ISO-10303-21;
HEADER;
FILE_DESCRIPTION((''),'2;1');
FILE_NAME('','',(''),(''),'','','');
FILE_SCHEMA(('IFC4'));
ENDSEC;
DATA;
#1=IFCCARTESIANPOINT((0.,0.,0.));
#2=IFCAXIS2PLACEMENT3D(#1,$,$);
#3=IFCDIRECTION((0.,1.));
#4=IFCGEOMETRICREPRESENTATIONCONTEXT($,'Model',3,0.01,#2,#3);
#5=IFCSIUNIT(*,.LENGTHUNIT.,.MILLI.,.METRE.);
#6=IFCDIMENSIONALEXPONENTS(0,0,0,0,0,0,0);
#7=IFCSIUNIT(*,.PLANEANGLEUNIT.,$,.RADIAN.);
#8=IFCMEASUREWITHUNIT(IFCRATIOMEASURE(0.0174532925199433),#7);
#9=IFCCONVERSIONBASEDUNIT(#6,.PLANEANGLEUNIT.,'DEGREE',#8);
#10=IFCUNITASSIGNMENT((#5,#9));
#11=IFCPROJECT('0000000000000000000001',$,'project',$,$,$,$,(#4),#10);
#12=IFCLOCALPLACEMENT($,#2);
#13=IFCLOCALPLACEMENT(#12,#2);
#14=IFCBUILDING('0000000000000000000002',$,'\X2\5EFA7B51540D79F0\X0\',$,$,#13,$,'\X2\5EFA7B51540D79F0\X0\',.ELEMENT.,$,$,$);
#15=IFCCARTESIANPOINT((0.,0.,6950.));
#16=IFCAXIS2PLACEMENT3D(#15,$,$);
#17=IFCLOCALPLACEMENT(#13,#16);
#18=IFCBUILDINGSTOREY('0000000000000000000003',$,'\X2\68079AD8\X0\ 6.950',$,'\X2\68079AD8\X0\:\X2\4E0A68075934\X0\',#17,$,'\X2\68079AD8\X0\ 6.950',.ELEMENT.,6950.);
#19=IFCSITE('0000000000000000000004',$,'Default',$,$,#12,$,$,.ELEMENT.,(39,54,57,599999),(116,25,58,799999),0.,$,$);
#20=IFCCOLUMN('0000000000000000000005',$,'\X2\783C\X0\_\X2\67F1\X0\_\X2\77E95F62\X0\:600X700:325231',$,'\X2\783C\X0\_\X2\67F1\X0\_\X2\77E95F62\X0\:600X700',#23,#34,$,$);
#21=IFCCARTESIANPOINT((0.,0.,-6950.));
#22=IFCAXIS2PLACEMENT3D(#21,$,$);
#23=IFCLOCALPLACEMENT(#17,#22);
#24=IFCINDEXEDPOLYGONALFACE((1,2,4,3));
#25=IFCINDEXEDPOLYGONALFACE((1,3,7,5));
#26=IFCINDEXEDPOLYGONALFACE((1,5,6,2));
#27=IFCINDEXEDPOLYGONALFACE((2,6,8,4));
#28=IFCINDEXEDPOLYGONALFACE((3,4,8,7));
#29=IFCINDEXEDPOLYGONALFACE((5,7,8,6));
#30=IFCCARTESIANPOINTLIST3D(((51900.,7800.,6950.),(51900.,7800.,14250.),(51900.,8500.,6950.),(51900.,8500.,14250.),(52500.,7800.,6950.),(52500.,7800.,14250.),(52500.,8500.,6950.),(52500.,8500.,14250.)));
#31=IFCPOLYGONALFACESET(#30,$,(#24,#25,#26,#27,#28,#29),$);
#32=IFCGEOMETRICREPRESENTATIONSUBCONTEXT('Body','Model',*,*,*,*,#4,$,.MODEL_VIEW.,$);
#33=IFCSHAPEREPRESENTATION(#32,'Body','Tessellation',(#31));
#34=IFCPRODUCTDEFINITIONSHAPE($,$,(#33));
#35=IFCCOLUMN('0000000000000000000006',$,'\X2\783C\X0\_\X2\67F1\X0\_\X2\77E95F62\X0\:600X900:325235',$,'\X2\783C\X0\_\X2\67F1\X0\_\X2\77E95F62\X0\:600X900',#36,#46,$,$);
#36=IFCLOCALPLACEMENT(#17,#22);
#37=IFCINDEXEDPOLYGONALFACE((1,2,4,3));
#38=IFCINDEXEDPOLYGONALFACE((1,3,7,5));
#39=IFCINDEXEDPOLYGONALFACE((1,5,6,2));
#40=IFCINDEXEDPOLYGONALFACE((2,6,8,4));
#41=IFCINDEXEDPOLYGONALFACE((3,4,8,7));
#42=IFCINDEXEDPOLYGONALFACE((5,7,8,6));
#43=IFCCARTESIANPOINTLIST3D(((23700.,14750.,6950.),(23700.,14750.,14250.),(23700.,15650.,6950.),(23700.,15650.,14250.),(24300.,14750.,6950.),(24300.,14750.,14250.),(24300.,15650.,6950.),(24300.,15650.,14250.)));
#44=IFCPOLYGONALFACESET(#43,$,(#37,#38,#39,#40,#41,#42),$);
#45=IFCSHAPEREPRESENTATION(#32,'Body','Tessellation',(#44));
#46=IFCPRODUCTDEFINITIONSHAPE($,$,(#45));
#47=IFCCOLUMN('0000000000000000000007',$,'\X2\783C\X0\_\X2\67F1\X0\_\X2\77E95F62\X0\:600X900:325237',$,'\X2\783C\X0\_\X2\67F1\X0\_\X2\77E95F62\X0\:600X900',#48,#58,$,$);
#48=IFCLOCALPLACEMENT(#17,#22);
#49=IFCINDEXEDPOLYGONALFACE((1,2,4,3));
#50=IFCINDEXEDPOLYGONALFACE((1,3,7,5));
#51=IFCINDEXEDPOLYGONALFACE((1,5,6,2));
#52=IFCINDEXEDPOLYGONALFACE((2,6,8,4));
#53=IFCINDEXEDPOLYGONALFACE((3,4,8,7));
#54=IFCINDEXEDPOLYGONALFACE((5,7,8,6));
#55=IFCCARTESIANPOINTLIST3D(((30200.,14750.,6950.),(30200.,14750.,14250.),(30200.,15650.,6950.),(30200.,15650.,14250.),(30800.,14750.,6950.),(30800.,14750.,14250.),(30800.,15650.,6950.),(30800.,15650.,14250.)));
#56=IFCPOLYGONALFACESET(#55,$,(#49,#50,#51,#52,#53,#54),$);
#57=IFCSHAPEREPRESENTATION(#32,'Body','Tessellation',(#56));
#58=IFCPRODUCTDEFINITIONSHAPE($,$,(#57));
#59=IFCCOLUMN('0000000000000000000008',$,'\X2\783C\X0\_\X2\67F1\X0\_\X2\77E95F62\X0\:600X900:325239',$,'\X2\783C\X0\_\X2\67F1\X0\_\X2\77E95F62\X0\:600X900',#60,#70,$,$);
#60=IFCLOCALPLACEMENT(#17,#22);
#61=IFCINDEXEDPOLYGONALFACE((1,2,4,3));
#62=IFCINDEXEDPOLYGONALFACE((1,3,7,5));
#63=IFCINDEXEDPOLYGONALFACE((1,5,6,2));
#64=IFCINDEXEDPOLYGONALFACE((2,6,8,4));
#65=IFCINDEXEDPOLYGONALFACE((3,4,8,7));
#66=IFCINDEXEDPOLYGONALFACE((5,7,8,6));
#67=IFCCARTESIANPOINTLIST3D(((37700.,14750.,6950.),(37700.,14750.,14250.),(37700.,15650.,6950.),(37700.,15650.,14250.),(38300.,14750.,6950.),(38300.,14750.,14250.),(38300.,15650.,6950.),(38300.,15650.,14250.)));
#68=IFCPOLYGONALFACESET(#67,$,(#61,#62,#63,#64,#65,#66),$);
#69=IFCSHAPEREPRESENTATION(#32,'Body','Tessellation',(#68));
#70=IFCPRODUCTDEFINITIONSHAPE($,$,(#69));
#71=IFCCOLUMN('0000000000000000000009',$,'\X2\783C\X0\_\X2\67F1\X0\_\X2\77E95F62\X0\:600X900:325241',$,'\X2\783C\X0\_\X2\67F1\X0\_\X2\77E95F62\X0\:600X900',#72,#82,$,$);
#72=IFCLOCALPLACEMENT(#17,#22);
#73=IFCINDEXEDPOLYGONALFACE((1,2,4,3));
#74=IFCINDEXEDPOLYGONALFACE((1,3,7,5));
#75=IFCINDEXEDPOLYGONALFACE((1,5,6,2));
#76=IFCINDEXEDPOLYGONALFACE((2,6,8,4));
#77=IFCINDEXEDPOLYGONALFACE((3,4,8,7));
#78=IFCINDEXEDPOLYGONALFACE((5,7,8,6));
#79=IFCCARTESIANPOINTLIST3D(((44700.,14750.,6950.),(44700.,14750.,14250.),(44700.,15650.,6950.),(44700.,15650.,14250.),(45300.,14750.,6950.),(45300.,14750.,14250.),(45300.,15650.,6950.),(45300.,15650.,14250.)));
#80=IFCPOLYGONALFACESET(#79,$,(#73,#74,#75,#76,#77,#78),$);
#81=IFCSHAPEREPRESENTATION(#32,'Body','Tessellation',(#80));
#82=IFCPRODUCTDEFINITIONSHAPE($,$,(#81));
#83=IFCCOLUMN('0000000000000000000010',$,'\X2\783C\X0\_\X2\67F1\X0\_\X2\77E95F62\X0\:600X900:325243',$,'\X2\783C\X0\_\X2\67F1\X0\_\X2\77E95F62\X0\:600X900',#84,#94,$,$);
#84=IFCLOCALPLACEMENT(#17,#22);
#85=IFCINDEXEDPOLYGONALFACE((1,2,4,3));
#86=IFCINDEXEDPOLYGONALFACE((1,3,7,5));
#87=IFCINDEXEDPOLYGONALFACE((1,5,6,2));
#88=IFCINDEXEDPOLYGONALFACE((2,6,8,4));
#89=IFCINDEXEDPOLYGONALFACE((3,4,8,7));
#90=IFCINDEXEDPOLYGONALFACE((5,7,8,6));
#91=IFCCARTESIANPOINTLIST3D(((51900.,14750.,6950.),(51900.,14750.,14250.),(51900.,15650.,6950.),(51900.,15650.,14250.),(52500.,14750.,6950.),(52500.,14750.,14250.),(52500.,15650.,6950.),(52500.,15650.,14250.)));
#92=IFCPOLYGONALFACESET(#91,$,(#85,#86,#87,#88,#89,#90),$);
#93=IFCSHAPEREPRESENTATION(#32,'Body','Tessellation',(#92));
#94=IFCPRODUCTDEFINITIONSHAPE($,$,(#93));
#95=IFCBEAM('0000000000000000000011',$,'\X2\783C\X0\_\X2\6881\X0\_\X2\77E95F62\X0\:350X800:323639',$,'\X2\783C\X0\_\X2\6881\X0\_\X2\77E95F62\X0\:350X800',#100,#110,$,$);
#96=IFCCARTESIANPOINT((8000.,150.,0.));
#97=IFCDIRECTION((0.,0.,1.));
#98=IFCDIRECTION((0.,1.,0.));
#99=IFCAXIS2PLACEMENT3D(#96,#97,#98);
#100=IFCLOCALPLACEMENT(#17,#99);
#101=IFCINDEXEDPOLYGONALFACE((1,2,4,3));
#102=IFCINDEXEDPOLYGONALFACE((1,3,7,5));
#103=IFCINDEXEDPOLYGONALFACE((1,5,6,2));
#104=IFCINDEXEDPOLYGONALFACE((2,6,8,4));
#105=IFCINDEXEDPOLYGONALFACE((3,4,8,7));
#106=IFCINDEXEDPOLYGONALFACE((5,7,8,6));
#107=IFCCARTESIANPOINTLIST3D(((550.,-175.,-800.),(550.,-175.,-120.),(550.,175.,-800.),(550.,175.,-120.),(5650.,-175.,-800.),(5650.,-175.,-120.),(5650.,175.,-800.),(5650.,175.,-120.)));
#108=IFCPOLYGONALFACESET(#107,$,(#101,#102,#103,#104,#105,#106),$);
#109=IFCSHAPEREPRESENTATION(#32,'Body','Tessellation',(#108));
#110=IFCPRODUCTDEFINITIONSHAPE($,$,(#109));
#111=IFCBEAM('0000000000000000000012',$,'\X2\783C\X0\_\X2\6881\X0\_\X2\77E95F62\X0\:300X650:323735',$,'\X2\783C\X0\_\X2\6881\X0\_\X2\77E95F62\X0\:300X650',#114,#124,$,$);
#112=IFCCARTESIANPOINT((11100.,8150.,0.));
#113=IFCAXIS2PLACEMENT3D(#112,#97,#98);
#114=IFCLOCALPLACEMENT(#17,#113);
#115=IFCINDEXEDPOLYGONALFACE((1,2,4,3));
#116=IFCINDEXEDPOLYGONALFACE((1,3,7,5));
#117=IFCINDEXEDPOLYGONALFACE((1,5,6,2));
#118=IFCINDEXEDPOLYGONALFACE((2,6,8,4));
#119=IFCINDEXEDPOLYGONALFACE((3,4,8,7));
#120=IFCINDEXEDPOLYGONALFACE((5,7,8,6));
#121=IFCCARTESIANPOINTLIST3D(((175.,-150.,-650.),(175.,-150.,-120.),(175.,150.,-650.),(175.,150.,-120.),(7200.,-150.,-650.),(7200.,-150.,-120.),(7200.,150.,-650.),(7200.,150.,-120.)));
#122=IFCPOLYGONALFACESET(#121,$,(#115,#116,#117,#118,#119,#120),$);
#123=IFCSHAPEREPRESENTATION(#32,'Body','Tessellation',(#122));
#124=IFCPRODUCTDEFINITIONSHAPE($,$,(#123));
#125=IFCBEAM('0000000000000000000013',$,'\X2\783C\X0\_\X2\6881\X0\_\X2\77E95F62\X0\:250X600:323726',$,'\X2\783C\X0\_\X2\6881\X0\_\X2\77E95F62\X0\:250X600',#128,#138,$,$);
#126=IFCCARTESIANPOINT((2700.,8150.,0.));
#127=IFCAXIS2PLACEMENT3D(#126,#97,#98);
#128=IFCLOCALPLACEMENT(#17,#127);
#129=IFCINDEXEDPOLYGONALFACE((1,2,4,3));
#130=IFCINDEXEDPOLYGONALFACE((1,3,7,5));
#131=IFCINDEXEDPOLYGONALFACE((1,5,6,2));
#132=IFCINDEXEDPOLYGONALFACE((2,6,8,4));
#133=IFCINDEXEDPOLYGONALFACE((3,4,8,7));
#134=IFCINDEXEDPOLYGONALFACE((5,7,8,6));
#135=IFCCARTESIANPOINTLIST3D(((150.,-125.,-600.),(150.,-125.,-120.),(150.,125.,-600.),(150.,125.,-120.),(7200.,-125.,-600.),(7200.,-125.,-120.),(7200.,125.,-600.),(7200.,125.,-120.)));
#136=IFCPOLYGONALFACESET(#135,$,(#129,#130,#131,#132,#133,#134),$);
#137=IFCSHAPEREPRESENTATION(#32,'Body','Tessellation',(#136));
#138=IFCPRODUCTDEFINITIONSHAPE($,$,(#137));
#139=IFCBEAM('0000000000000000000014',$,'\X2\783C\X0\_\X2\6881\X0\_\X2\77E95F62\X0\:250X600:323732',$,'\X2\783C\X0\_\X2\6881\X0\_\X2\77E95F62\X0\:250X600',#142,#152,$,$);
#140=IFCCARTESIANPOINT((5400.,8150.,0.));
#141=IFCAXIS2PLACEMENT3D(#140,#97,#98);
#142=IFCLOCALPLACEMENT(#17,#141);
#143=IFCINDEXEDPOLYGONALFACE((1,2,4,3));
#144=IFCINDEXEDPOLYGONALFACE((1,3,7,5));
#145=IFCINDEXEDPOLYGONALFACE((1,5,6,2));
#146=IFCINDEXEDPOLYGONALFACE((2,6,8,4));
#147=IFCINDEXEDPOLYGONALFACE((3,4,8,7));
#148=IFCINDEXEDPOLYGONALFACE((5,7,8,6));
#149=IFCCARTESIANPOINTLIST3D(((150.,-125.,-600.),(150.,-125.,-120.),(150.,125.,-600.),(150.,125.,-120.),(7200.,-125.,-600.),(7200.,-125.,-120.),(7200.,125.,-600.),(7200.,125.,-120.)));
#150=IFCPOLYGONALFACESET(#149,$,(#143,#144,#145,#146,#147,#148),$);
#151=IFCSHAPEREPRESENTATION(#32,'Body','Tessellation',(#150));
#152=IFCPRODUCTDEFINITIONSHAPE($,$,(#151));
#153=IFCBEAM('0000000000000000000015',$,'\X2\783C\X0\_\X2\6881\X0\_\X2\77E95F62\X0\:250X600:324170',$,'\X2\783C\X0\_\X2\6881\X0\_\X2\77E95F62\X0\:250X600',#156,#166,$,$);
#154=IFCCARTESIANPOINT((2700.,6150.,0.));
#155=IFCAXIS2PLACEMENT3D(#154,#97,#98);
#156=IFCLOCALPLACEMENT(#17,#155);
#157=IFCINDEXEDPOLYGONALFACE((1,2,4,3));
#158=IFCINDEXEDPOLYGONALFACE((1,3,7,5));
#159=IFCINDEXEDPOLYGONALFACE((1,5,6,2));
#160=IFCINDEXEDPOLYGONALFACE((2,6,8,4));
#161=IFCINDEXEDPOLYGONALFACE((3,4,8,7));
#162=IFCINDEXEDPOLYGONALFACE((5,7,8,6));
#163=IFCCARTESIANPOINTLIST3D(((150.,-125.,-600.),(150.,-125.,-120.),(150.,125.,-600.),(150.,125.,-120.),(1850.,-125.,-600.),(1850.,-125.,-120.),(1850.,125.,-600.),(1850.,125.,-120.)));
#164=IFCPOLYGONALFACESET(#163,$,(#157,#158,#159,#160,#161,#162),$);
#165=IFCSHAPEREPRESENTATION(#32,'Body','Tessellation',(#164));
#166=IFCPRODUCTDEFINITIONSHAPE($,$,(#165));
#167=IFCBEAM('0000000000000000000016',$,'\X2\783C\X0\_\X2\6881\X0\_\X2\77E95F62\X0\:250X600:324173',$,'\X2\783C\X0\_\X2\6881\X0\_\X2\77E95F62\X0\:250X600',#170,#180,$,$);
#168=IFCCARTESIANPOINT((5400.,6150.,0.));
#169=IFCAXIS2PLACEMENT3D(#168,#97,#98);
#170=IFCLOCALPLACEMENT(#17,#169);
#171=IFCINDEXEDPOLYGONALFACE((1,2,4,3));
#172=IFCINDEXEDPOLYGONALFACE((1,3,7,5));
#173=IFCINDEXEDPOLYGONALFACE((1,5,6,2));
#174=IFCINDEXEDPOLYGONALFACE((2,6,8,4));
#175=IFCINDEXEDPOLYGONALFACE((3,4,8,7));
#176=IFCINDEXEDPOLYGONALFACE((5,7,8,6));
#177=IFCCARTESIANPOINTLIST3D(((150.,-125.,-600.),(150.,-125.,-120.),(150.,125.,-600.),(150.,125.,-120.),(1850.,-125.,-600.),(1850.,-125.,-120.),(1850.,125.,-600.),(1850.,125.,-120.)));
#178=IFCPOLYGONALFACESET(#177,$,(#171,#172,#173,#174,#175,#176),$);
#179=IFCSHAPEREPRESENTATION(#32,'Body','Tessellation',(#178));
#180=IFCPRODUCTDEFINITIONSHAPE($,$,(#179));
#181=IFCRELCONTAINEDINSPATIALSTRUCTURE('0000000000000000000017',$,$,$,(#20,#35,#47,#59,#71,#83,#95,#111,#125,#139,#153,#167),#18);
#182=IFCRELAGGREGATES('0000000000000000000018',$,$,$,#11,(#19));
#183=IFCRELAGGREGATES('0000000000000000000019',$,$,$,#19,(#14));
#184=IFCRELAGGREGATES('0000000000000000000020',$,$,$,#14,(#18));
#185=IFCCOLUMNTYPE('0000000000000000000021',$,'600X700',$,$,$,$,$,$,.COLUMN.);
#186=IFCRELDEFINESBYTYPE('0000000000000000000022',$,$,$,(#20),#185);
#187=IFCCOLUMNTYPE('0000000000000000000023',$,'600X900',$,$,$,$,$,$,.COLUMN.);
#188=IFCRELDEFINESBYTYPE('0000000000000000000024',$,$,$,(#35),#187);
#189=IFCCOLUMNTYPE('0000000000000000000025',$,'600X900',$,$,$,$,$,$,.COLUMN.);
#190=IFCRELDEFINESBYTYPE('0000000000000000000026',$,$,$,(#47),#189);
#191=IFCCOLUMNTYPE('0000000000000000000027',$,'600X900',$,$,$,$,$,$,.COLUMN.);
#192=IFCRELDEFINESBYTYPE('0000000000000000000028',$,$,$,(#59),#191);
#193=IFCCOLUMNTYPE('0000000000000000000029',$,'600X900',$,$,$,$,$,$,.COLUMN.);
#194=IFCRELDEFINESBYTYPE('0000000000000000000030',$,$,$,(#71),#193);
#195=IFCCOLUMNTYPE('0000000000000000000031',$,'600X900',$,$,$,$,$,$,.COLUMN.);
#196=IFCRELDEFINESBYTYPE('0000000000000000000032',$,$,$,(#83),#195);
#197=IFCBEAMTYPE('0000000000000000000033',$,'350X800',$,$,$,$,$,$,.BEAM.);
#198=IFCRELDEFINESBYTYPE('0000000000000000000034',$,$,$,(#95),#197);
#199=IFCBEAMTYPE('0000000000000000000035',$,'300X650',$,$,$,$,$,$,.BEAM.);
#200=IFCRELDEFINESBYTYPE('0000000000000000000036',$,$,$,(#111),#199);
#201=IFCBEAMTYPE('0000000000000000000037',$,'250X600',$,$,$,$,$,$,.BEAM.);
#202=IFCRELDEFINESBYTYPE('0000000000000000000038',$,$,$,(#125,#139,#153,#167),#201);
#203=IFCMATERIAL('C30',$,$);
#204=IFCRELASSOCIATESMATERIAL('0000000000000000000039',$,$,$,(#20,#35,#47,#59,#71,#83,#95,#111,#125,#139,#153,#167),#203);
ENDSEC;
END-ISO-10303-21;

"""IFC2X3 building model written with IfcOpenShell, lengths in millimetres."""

from ifc_helpers import new_model, entity, si_unit, converted_unit, direction, frame, frame_2d, origin, origin_2d_with_axis, place, context, subcontext, project, spatial, rectangle, extrude, source, transform, mapped, material, type_object, type_shapes, element, save


model = new_model("IFC2X3")

# Units and contexts
model_context = context("Model", 3, precision=0.01, world=origin(), true_north=direction((0.0, 1.0)))
body_context = subcontext(model_context, "Body", "Model", "MODEL_VIEW")
ifc_project = project(units=[si_unit("LENGTHUNIT", "METRE", prefix="MILLI"), converted_unit("PLANEANGLEUNIT", "DEGREE", entity("IfcRatioMeasure", 0.0174532925199433), si_unit("PLANEANGLEUNIT", "RADIAN"), dimensions=[0, 0, 0, 0, 0, 0, 0])], contexts=[model_context])

# Site, building, storey
site_placement = place(None, origin())
site = spatial("IfcSite", under=ifc_project, at=site_placement, Name="Default", CompositionType="ELEMENT", RefLatitude=(39, 54, 57, 599999), RefLongitude=(116, 25, 58, 799999), RefElevation=0.0)
building_placement = place(site_placement, origin())
building = spatial("IfcBuilding", under=site, at=building_placement, Name="建筑名称", LongName="建筑名称", CompositionType="ELEMENT")
storey_placement = place(building_placement, frame((0.0, 0.0, 6950.0)))
storey = spatial("IfcBuildingStorey", under=building, at=storey_placement, Name="标高 6.950", ObjectType="标高:上标头", LongName="标高 6.950", CompositionType="ELEMENT", Elevation=6950.0)

# Columns
ifc_material = material(Name="C30")
column_type_1 = type_object("IfcColumnType", Name="600X700", PredefinedType="COLUMN")
shared_shape_1 = source(origin(), body_context, "Body", "SweptSolid", [
    extrude(rectangle(XDim=700.0, YDim=600.0, at=origin_2d_with_axis()), frame((52200.0, 8150.0, 6950.0), z_axis=(0.0, 0.0, 1.0), x_axis=(0.0, -1.0, 0.0)), (0.0, 0.0, 1.0), 7300.0),
])
type_shapes(column_type_1, [shared_shape_1])
column_1_placement = place(storey_placement, frame((0.0, 0.0, -6950.0)))
element("IfcColumn", 1, at=column_1_placement, inside=storey, type_object=column_type_1, material=ifc_material, Name="砼_柱_矩形:600X700:325231", ObjectType="砼_柱_矩形:600X700", context=body_context, shape_type="MappedRepresentation", body=[
    mapped(shared_shape_1, transform((0.0, 0.0, 0.0), scale=1.0)),
])
column_type_2 = type_object("IfcColumnType", Name="600X900", PredefinedType="COLUMN")
shared_shape_2 = source(origin(), body_context, "Body", "SweptSolid", [
    extrude(rectangle(XDim=900.0, YDim=600.0, at=origin_2d_with_axis()), frame((24000.0, 15200.0, 6950.0), z_axis=(0.0, 0.0, 1.0), x_axis=(0.0, -1.0, 0.0)), (0.0, 0.0, 1.0), 7300.0),
])
type_shapes(column_type_2, [shared_shape_2])
column_2_placement = place(storey_placement, frame((0.0, 0.0, -6950.0)))
element("IfcColumn", 2, at=column_2_placement, inside=storey, type_object=column_type_2, material=ifc_material, Name="砼_柱_矩形:600X900:325235", ObjectType="砼_柱_矩形:600X900", context=body_context, shape_type="MappedRepresentation", body=[
    mapped(shared_shape_2, transform((0.0, 0.0, 0.0), scale=1.0)),
])
column_type_3 = type_object("IfcColumnType", Name="600X900", PredefinedType="COLUMN")
shared_shape_3 = source(origin(), body_context, "Body", "SweptSolid", [
    extrude(rectangle(XDim=900.0, YDim=600.0, at=origin_2d_with_axis()), frame((30500.0, 15200.0, 6950.0), z_axis=(0.0, 0.0, 1.0), x_axis=(0.0, -1.0, 0.0)), (0.0, 0.0, 1.0), 7300.0),
])
type_shapes(column_type_3, [shared_shape_3])
column_3_placement = place(storey_placement, frame((0.0, 0.0, -6950.0)))
element("IfcColumn", 3, at=column_3_placement, inside=storey, type_object=column_type_3, material=ifc_material, Name="砼_柱_矩形:600X900:325237", ObjectType="砼_柱_矩形:600X900", context=body_context, shape_type="MappedRepresentation", body=[
    mapped(shared_shape_3, transform((0.0, 0.0, 0.0), scale=1.0)),
])
column_type_4 = type_object("IfcColumnType", Name="600X900", PredefinedType="COLUMN")
shared_shape_4 = source(origin(), body_context, "Body", "SweptSolid", [
    extrude(rectangle(XDim=900.0, YDim=600.0, at=origin_2d_with_axis()), frame((38000.0, 15200.0, 6950.0), z_axis=(0.0, 0.0, 1.0), x_axis=(0.0, -1.0, 0.0)), (0.0, 0.0, 1.0), 7300.0),
])
type_shapes(column_type_4, [shared_shape_4])
column_4_placement = place(storey_placement, frame((0.0, 0.0, -6950.0)))
element("IfcColumn", 4, at=column_4_placement, inside=storey, type_object=column_type_4, material=ifc_material, Name="砼_柱_矩形:600X900:325239", ObjectType="砼_柱_矩形:600X900", context=body_context, shape_type="MappedRepresentation", body=[
    mapped(shared_shape_4, transform((0.0, 0.0, 0.0), scale=1.0)),
])
column_type_5 = type_object("IfcColumnType", Name="600X900", PredefinedType="COLUMN")
shared_shape_5 = source(origin(), body_context, "Body", "SweptSolid", [
    extrude(rectangle(XDim=900.0, YDim=600.0, at=origin_2d_with_axis()), frame((45000.0, 15200.0, 6950.0), z_axis=(0.0, 0.0, 1.0), x_axis=(0.0, -1.0, 0.0)), (0.0, 0.0, 1.0), 7300.0),
])
type_shapes(column_type_5, [shared_shape_5])
column_5_placement = place(storey_placement, frame((0.0, 0.0, -6950.0)))
element("IfcColumn", 5, at=column_5_placement, inside=storey, type_object=column_type_5, material=ifc_material, Name="砼_柱_矩形:600X900:325241", ObjectType="砼_柱_矩形:600X900", context=body_context, shape_type="MappedRepresentation", body=[
    mapped(shared_shape_5, transform((0.0, 0.0, 0.0), scale=1.0)),
])
column_type_6 = type_object("IfcColumnType", Name="600X900", PredefinedType="COLUMN")
shared_shape_6 = source(origin(), body_context, "Body", "SweptSolid", [
    extrude(rectangle(XDim=900.0, YDim=600.0, at=origin_2d_with_axis()), frame((52200.0, 15200.0, 6950.0), z_axis=(0.0, 0.0, 1.0), x_axis=(0.0, -1.0, 0.0)), (0.0, 0.0, 1.0), 7300.0),
])
type_shapes(column_type_6, [shared_shape_6])
column_6_placement = place(storey_placement, frame((0.0, 0.0, -6950.0)))
element("IfcColumn", 6, at=column_6_placement, inside=storey, type_object=column_type_6, material=ifc_material, Name="砼_柱_矩形:600X900:325243", ObjectType="砼_柱_矩形:600X900", context=body_context, shape_type="MappedRepresentation", body=[
    mapped(shared_shape_6, transform((0.0, 0.0, 0.0), scale=1.0)),
])

# Beams
beam_type_1 = type_object("IfcBeamType", Name="350X800", PredefinedType="BEAM")
beam_1_placement = place(storey_placement, frame((8000.0, 150.0, 0.0), z_axis=(0.0, 0.0, 1.0), x_axis=(0.0, 1.0, 0.0)))
element("IfcBeam", 7, at=beam_1_placement, inside=storey, type_object=beam_type_1, material=ifc_material, Name="砼_梁_矩形:350X800:323639", ObjectType="砼_梁_矩形:350X800", context=body_context, shape_type="SweptSolid", body=[
    extrude(rectangle(XDim=680.0, YDim=350.0, at=frame_2d((0.0, 0.0), x_axis=(1.0, 0.0))), frame((550.0, 0.0, -460.0), z_axis=(1.0, 0.0, 0.0), x_axis=(0.0, 0.0, -1.0)), (0.0, 0.0, 1.0), 5100.0),
])
beam_type_2 = type_object("IfcBeamType", Name="300X650", PredefinedType="BEAM")
beam_2_placement = place(storey_placement, frame((11100.0, 8150.0, 0.0), z_axis=(0.0, 0.0, 1.0), x_axis=(0.0, 1.0, 0.0)))
element("IfcBeam", 8, at=beam_2_placement, inside=storey, type_object=beam_type_2, material=ifc_material, Name="砼_梁_矩形:300X650:323735", ObjectType="砼_梁_矩形:300X650", context=body_context, shape_type="SweptSolid", body=[
    extrude(rectangle(XDim=530.0, YDim=300.0, at=frame_2d((0.0, 0.0), x_axis=(1.0, 0.0))), frame((175.0, 0.0, -385.0), z_axis=(1.0, 0.0, 0.0), x_axis=(0.0, 0.0, -1.0)), (0.0, 0.0, 1.0), 7025.0),
])
beam_type_3 = type_object("IfcBeamType", Name="250X600", PredefinedType="BEAM")
beam_3_placement = place(storey_placement, frame((2700.0, 8150.0, 0.0), z_axis=(0.0, 0.0, 1.0), x_axis=(0.0, 1.0, 0.0)))
element("IfcBeam", 9, at=beam_3_placement, inside=storey, type_object=beam_type_3, material=ifc_material, Name="砼_梁_矩形:250X600:323726", ObjectType="砼_梁_矩形:250X600", context=body_context, shape_type="SweptSolid", body=[
    extrude(rectangle(XDim=480.0, YDim=250.0, at=frame_2d((0.0, 0.0), x_axis=(1.0, 0.0))), frame((150.0, 0.0, -360.0), z_axis=(1.0, 0.0, 0.0), x_axis=(0.0, 0.0, -1.0)), (0.0, 0.0, 1.0), 7050.0),
])
beam_4_placement = place(storey_placement, frame((5400.0, 8150.0, 0.0), z_axis=(0.0, 0.0, 1.0), x_axis=(0.0, 1.0, 0.0)))
element("IfcBeam", 10, at=beam_4_placement, inside=storey, type_object=beam_type_3, material=ifc_material, Name="砼_梁_矩形:250X600:323732", ObjectType="砼_梁_矩形:250X600", context=body_context, shape_type="SweptSolid", body=[
    extrude(rectangle(XDim=480.0, YDim=250.0, at=frame_2d((0.0, 0.0), x_axis=(1.0, 0.0))), frame((150.0, 0.0, -360.0), z_axis=(1.0, 0.0, 0.0), x_axis=(0.0, 0.0, -1.0)), (0.0, 0.0, 1.0), 7050.0),
])
beam_5_placement = place(storey_placement, frame((2700.0, 6150.0, 0.0), z_axis=(0.0, 0.0, 1.0), x_axis=(0.0, 1.0, 0.0)))
element("IfcBeam", 11, at=beam_5_placement, inside=storey, type_object=beam_type_3, material=ifc_material, Name="砼_梁_矩形:250X600:324170", ObjectType="砼_梁_矩形:250X600", context=body_context, shape_type="SweptSolid", body=[
    extrude(rectangle(XDim=480.0, YDim=250.0, at=frame_2d((0.0, 0.0), x_axis=(1.0, 0.0))), frame((150.0, 0.0, -360.0), z_axis=(1.0, 0.0, 0.0), x_axis=(0.0, 0.0, -1.0)), (0.0, 0.0, 1.0), 1700.0),
])
beam_6_placement = place(storey_placement, frame((5400.0, 6150.0, 0.0), z_axis=(0.0, 0.0, 1.0), x_axis=(0.0, 1.0, 0.0)))
element("IfcBeam", 12, at=beam_6_placement, inside=storey, type_object=beam_type_3, material=ifc_material, Name="砼_梁_矩形:250X600:324173", ObjectType="砼_梁_矩形:250X600", context=body_context, shape_type="SweptSolid", body=[
    extrude(rectangle(XDim=480.0, YDim=250.0, at=frame_2d((0.0, 0.0), x_axis=(1.0, 0.0))), frame((150.0, 0.0, -360.0), z_axis=(1.0, 0.0, 0.0), x_axis=(0.0, 0.0, -1.0)), (0.0, 0.0, 1.0), 1700.0),
])

save(model, "model.ifc")
